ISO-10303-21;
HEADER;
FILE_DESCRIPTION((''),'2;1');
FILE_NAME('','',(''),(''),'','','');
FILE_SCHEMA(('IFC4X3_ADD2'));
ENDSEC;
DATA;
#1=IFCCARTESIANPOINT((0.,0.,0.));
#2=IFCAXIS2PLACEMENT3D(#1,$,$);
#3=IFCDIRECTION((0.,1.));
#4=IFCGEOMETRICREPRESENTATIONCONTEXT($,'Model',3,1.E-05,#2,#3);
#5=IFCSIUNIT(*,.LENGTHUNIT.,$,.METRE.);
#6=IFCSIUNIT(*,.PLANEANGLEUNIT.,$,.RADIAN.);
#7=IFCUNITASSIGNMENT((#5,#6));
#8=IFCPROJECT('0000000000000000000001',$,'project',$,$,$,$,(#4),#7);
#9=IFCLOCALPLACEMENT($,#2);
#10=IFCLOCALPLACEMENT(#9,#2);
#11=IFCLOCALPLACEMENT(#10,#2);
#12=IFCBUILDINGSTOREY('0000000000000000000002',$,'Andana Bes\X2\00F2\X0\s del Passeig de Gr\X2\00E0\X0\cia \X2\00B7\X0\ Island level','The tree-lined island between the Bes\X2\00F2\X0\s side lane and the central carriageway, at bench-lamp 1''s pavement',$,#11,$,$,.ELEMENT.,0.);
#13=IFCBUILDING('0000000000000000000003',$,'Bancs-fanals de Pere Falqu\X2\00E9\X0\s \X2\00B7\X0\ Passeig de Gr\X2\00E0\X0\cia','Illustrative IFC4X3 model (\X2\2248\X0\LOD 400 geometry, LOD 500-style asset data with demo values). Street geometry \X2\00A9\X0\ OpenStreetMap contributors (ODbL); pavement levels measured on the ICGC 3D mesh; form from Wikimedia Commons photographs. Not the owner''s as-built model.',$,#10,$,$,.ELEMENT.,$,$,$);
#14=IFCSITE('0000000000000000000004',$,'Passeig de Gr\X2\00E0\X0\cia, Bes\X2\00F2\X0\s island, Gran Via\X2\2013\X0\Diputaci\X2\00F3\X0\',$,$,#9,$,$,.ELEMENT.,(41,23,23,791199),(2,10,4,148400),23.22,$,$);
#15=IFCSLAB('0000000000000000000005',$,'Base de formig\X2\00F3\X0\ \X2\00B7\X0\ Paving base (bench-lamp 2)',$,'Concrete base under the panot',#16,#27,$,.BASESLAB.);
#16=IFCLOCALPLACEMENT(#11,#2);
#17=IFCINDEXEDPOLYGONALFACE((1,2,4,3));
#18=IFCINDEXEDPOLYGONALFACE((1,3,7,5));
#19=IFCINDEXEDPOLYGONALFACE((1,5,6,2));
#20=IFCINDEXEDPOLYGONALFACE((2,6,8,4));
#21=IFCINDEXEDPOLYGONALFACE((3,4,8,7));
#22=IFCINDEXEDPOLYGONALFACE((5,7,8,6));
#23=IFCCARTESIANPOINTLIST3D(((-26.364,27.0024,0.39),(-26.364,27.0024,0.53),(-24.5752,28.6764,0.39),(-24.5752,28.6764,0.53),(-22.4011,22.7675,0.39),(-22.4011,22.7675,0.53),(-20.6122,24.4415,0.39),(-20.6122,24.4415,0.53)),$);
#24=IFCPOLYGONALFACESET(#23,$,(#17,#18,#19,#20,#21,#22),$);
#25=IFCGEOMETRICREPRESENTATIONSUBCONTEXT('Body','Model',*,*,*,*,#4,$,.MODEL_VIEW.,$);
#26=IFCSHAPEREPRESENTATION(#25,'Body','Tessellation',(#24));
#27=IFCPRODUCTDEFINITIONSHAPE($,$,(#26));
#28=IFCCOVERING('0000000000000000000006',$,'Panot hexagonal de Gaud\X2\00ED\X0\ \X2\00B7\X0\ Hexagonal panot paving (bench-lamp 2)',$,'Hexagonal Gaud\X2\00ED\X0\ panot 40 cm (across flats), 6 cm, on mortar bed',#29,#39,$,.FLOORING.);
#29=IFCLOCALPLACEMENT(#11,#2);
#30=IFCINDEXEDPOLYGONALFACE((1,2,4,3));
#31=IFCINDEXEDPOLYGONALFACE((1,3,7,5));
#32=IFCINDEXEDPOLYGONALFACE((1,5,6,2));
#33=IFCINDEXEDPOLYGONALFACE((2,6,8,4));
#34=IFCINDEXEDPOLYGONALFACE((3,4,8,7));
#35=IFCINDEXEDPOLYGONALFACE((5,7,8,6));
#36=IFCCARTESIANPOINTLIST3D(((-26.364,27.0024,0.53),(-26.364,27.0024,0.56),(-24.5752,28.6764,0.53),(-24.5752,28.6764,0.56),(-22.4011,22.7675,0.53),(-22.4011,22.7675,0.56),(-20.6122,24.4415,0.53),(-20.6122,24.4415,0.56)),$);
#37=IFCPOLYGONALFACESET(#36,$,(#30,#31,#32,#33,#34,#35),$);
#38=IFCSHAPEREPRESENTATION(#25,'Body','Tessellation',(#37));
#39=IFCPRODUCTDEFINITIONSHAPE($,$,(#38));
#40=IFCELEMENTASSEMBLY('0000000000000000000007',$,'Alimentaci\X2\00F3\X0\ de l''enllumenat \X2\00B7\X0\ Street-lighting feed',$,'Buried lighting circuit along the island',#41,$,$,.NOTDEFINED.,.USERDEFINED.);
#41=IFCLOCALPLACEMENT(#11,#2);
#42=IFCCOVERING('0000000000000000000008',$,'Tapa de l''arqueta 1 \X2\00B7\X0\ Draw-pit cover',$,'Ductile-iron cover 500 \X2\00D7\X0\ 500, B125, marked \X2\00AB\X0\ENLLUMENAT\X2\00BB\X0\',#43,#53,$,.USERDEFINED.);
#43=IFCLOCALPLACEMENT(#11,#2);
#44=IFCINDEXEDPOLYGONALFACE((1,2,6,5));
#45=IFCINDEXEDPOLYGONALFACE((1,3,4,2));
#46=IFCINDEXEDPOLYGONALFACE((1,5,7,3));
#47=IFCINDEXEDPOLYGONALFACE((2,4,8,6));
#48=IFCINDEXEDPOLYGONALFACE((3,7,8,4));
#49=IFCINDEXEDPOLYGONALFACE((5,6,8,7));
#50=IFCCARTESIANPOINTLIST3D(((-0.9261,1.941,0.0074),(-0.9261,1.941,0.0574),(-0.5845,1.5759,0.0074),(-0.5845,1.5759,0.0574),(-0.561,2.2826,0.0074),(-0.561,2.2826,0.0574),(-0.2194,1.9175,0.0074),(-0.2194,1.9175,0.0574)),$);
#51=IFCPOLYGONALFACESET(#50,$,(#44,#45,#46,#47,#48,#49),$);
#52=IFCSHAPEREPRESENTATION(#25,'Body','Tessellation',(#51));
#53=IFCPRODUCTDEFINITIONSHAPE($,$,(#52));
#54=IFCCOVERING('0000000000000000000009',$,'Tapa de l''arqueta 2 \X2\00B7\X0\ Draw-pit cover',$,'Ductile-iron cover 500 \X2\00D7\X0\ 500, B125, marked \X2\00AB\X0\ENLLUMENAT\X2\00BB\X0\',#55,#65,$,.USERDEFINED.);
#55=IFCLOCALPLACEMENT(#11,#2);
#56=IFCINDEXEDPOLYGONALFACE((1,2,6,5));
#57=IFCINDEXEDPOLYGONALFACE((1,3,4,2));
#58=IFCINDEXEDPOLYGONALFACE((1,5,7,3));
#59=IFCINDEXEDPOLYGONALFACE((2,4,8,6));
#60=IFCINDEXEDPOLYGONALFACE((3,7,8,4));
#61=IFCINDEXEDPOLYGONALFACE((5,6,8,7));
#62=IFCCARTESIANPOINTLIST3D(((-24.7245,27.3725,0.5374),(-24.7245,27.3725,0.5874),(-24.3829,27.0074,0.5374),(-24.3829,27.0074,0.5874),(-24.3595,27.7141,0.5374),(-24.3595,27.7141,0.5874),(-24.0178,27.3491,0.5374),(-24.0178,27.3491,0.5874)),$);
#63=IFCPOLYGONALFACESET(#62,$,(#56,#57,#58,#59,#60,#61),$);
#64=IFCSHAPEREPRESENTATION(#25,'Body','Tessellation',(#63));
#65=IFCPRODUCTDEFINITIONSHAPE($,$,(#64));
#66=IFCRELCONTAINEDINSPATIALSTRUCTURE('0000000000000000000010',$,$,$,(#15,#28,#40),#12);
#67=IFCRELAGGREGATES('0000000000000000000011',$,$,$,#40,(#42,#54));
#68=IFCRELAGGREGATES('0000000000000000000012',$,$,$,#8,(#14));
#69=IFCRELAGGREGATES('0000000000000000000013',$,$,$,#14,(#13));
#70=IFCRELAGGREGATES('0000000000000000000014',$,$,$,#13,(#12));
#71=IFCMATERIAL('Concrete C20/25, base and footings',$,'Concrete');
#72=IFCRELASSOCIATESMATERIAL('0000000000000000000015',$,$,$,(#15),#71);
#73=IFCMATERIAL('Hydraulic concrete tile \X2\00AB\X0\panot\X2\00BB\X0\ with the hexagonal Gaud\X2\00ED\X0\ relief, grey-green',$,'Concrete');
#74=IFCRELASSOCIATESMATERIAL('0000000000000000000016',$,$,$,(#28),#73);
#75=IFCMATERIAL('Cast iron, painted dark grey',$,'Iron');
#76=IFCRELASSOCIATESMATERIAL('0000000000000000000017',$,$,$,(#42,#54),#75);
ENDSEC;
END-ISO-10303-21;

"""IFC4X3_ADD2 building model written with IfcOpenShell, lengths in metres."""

from ifc_helpers import new_model, si_unit, direction, frame, frame_2d, origin, place, context, subcontext, project, spatial, rectangle, extrude, material, element, aggregate, save


model = new_model("IFC4X3_ADD2")

# Units and contexts
model_context = context("Model", 3, precision=1e-05, world=origin(), true_north=direction((0.0, 1.0)))
body_context = subcontext(model_context, "Body", "Model", "MODEL_VIEW")
ifc_project = project(units=[si_unit("LENGTHUNIT", "METRE"), si_unit("PLANEANGLEUNIT", "RADIAN")], contexts=[model_context])

# Site, building, storey
site_placement = place(None, origin())
site = spatial("IfcSite", under=ifc_project, at=site_placement, Name="Passeig de Gràcia, Besòs island, Gran Via–Diputació", CompositionType="ELEMENT", RefLatitude=(41, 23, 23, 791199), RefLongitude=(2, 10, 4, 148400), RefElevation=23.22)
building_placement = place(site_placement, origin())
building = spatial("IfcBuilding", under=site, at=building_placement, Name="Bancs-fanals de Pere Falqués · Passeig de Gràcia", Description="Illustrative IFC4X3 model (≈LOD 400 geometry, LOD 500-style asset data with demo values). Street geometry © OpenStreetMap contributors (ODbL); pavement levels measured on the ICGC 3D mesh; form from Wikimedia Commons photographs. Not the owner's as-built model.", CompositionType="ELEMENT")
storey_placement = place(building_placement, origin())
storey = spatial("IfcBuildingStorey", under=building, at=storey_placement, Name="Andana Besòs del Passeig de Gràcia · Island level", Description="The tree-lined island between the Besòs side lane and the central carriageway, at bench-lamp 1's pavement", CompositionType="ELEMENT", Elevation=0.0)

# Slab
ifc_material_1 = material(Name="Concrete C20/25, base and footings", Category="Concrete")
slab_placement = place(building_placement, origin())
element("IfcSlab", 1, at=slab_placement, inside=storey, material=ifc_material_1, Name="Base de formigó · Paving base (bench-lamp 2)", ObjectType="Concrete base under the panot", PredefinedType="BASESLAB", context=body_context, shape_type="SweptSolid", body=[
    extrude(rectangle(XDim=5.8, YDim=2.45, at=frame_2d((0.0, 0.0), x_axis=(-0.683274, 0.730162))), frame((-23.4881, 25.7219, 0.39)), (0.0, 0.0, 1.0), 0.14),
])

# Covering
ifc_material_2 = material(Name="Hydraulic concrete tile «panot» with the hexagonal Gaudí relief, grey-green", Category="Concrete")
covering_1_placement = place(building_placement, origin())
element("IfcCovering", 2, at=covering_1_placement, inside=storey, material=ifc_material_2, Name="Panot hexagonal de Gaudí · Hexagonal panot paving (bench-lamp 2)", ObjectType="Hexagonal Gaudí panot 40 cm (across flats), 6 cm, on mortar bed", PredefinedType="FLOORING", context=body_context, shape_type="SweptSolid", body=[
    extrude(rectangle(XDim=5.8, YDim=2.45, at=frame_2d((0.0, 0.0), x_axis=(-0.683274, 0.730162))), frame((-23.4881, 25.7219, 0.53)), (0.0, 0.0, 1.0), 0.03),
])

# Element assembly, coverings
assembly_1_placement = place(building_placement, origin())
assembly_1 = element("IfcElementAssembly", 3, at=assembly_1_placement, inside=storey, Name="Alimentació de l'enllumenat · Street-lighting feed", ObjectType="Buried lighting circuit along the island", AssemblyPlace="NOTDEFINED", PredefinedType="USERDEFINED")
ifc_material_3 = material(Name="Cast iron, painted dark grey", Category="Iron")
covering_2_placement = place(building_placement, origin())
covering_2 = element("IfcCovering", 4, at=covering_2_placement, material=ifc_material_3, Name="Tapa de l'arqueta 1 · Draw-pit cover", ObjectType="Ductile-iron cover 500 × 500, B125, marked «ENLLUMENAT»", PredefinedType="USERDEFINED", context=body_context, shape_type="SweptSolid", body=[
    extrude(rectangle(XDim=0.5, YDim=0.5, at=frame_2d((0.0, 0.0), x_axis=(-0.683274, 0.730162))), frame((-0.5727, 1.9292, 0.0074)), (0.0, 0.0, 1.0), 0.05),
])
covering_3_placement = place(building_placement, origin())
covering_3 = element("IfcCovering", 5, at=covering_3_placement, material=ifc_material_3, Name="Tapa de l'arqueta 2 · Draw-pit cover", ObjectType="Ductile-iron cover 500 × 500, B125, marked «ENLLUMENAT»", PredefinedType="USERDEFINED", context=body_context, shape_type="SweptSolid", body=[
    extrude(rectangle(XDim=0.5, YDim=0.5, at=frame_2d((0.0, 0.0), x_axis=(-0.683274, 0.730162))), frame((-24.3712, 27.3608, 0.5374)), (0.0, 0.0, 1.0), 0.05),
])

aggregate(assembly_1, [covering_2, covering_3])

save(model, "model.ifc")
